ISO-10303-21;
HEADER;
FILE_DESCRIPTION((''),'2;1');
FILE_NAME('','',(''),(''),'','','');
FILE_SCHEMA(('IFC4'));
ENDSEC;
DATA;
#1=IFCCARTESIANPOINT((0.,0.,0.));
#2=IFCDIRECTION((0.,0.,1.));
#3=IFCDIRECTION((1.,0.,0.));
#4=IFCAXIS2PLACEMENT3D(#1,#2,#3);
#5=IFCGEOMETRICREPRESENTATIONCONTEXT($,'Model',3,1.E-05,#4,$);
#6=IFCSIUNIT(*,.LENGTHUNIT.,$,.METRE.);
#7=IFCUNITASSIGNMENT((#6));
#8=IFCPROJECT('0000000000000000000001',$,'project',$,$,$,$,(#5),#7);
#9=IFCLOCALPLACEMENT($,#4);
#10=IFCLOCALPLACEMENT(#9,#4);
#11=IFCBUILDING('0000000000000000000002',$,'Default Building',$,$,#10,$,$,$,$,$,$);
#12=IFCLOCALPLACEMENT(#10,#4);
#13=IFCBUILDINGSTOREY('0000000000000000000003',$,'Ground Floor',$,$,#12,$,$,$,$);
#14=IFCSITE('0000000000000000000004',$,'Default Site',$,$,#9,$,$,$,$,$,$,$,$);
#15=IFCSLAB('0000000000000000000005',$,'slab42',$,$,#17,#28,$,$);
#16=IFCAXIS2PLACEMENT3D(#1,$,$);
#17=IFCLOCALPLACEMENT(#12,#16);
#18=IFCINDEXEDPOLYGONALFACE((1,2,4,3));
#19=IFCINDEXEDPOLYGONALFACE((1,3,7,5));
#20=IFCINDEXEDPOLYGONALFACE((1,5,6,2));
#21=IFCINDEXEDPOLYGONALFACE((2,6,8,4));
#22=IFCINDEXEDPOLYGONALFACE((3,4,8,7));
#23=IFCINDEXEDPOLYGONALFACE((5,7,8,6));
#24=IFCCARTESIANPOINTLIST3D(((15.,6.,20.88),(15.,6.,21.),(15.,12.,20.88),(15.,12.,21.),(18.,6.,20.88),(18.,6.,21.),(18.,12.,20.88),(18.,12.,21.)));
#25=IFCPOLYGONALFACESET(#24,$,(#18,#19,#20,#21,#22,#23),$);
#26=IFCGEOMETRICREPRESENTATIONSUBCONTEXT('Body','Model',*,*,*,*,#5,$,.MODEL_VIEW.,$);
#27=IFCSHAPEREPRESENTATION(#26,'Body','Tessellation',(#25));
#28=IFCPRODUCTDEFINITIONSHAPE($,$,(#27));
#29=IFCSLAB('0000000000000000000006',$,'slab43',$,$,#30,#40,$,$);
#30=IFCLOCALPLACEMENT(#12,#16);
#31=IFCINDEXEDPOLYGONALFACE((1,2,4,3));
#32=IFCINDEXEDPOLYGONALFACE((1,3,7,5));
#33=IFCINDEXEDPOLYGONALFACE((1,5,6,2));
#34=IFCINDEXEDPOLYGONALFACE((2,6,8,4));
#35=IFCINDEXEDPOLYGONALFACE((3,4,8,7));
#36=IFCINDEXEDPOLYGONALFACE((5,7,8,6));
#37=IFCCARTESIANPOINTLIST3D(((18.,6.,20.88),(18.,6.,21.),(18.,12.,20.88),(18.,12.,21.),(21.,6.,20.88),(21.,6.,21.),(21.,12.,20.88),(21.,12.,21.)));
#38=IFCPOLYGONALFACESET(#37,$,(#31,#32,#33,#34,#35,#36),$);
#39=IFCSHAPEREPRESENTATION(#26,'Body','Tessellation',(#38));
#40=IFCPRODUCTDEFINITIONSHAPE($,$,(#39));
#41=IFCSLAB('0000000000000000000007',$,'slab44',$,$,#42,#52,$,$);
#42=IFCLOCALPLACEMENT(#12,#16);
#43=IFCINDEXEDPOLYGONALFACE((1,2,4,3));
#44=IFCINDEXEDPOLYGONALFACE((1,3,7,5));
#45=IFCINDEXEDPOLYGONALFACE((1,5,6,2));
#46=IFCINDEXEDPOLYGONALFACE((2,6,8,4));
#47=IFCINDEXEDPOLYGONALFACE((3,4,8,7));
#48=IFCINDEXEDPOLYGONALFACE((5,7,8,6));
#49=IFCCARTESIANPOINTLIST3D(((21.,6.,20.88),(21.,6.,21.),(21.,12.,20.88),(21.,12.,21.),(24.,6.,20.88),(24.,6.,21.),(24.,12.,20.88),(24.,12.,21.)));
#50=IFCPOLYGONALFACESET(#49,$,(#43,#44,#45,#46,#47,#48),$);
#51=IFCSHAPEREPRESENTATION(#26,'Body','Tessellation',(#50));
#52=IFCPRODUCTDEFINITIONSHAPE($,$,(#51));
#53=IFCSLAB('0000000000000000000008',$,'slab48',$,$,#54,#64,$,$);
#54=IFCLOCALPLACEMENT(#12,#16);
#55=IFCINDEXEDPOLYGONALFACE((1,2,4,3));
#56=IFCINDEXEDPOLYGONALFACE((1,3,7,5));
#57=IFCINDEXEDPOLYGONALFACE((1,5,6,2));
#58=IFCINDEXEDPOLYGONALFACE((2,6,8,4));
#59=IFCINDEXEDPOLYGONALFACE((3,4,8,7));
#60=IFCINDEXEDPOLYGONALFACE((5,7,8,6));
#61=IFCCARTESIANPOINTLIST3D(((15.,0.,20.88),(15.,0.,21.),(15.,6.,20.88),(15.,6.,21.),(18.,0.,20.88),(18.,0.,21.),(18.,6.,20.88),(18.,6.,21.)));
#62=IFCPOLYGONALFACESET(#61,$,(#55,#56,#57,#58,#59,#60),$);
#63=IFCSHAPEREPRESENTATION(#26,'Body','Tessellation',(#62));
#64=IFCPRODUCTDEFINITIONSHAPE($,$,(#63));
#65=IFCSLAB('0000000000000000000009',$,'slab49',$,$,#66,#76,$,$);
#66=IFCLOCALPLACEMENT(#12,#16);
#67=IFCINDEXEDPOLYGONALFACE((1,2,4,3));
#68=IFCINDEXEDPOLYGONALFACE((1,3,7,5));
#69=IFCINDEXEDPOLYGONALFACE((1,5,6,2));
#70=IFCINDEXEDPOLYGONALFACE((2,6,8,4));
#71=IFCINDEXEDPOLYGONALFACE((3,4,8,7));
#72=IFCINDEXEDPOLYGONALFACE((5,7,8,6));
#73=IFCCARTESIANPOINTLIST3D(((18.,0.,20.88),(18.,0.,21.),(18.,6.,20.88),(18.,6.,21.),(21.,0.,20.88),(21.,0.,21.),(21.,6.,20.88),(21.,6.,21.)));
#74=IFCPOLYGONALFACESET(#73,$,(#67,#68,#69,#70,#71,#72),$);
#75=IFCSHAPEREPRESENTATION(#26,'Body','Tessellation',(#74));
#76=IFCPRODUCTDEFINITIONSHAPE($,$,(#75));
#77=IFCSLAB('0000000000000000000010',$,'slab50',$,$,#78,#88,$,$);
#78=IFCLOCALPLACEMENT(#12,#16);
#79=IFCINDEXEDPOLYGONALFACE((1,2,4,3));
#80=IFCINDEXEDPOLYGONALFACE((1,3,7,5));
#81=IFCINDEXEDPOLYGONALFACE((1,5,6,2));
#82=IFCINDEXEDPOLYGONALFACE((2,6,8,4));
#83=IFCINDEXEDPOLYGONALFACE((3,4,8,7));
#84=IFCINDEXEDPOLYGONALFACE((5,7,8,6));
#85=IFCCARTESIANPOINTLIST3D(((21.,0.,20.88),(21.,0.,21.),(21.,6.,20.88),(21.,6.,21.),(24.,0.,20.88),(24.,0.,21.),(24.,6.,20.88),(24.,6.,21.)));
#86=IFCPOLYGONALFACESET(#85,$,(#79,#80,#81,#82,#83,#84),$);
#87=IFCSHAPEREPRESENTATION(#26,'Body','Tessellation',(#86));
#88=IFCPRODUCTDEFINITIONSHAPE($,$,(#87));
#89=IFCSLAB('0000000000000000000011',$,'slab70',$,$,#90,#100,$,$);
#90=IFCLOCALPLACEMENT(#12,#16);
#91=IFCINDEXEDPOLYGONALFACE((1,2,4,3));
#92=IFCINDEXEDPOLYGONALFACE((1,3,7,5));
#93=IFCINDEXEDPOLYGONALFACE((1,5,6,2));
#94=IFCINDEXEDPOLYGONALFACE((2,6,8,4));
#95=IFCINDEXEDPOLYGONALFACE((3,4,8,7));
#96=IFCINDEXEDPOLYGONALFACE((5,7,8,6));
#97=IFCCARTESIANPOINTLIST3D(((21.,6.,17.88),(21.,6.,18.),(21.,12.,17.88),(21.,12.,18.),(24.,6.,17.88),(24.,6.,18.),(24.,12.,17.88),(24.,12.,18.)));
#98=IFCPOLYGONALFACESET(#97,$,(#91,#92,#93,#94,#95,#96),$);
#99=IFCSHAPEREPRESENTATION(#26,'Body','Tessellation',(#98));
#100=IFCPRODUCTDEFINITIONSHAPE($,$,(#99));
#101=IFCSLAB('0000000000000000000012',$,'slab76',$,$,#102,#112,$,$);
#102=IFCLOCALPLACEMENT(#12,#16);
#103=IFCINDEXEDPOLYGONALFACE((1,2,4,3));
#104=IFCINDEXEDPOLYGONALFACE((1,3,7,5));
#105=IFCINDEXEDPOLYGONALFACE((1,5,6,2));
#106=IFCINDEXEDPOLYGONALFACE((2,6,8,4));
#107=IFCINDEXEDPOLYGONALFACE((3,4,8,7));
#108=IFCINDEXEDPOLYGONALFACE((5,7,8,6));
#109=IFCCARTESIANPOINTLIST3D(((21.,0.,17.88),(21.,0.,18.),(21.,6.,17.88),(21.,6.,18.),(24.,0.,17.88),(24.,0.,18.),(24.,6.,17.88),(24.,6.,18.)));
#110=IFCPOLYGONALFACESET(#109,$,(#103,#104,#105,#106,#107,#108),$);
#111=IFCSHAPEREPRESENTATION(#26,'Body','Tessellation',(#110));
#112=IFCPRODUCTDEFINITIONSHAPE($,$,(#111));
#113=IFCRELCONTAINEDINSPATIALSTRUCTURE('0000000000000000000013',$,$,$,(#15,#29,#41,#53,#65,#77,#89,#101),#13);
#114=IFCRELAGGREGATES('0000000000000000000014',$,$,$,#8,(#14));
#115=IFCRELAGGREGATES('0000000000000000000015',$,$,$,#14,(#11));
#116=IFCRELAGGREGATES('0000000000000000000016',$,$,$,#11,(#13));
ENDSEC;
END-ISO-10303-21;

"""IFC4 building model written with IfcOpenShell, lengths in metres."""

from ifc_helpers import new_model, si_unit, frame, origin_with_axes, place, context, subcontext, project, spatial, indexed_curve, outline, extrude, element, save


model = new_model("IFC4")

# Units and contexts
model_context = context("Model", 3, precision=1e-05, world=origin_with_axes())
body_context = subcontext(model_context, "Body", "Model", "MODEL_VIEW")
ifc_project = project(units=[si_unit("LENGTHUNIT", "METRE")], contexts=[model_context])

# Site, building, storey
site_placement = place(None, origin_with_axes())
site = spatial("IfcSite", under=ifc_project, at=site_placement, Name="Default Site")
building_placement = place(site_placement, origin_with_axes())
building = spatial("IfcBuilding", under=site, at=building_placement, Name="Default Building")
storey_placement = place(building_placement, origin_with_axes())
storey = spatial("IfcBuildingStorey", under=building, at=storey_placement, Name="Ground Floor")

# Slabs
for number, where, z_axis, x_axis, name in (
    (1, (15.0, 6.0, 20.88), (0.0, 0.0, 1.0), (1.0, 0.0, 0.0), "slab42"),
    (2, (18.0, 6.0, 20.88), (0.0, 0.0, 1.0), (1.0, 0.0, 0.0), "slab43"),
    (3, (21.0, 6.0, 20.88), (0.0, 0.0, 1.0), (1.0, 0.0, 0.0), "slab44"),
    (4, (15.0, 0.0, 20.88), (0.0, 0.0, 1.0), (1.0, 0.0, 0.0), "slab48"),
    (5, (18.0, 0.0, 20.88), (0.0, 0.0, 1.0), (1.0, 0.0, 0.0), "slab49"),
    (6, (21.0, 0.0, 20.88), (0.0, 0.0, 1.0), (1.0, 0.0, 0.0), "slab50"),
    (7, (21.0, 6.0, 17.88), (0.0, 0.0, 1.0), (1.0, 0.0, 0.0), "slab70"),
    (8, (21.0, 0.0, 17.88), (0.0, 0.0, 1.0), (1.0, 0.0, 0.0), "slab76"),
):
    element("IfcSlab", number, at=place(storey_placement, frame(where, z_axis=z_axis, x_axis=x_axis)), inside=storey, Name=name, context=body_context, shape_type="SweptSolid", body=[
        extrude(outline(indexed_curve([(0.0, 0.0), (0.0, 6.0), (3.0, 6.0), (3.0, 0.0), (0.0, 0.0)], self_intersect=False)), origin_with_axes(), (0.0, 0.0, 1.0), 0.12),
    ])

save(model, "model.ifc")
